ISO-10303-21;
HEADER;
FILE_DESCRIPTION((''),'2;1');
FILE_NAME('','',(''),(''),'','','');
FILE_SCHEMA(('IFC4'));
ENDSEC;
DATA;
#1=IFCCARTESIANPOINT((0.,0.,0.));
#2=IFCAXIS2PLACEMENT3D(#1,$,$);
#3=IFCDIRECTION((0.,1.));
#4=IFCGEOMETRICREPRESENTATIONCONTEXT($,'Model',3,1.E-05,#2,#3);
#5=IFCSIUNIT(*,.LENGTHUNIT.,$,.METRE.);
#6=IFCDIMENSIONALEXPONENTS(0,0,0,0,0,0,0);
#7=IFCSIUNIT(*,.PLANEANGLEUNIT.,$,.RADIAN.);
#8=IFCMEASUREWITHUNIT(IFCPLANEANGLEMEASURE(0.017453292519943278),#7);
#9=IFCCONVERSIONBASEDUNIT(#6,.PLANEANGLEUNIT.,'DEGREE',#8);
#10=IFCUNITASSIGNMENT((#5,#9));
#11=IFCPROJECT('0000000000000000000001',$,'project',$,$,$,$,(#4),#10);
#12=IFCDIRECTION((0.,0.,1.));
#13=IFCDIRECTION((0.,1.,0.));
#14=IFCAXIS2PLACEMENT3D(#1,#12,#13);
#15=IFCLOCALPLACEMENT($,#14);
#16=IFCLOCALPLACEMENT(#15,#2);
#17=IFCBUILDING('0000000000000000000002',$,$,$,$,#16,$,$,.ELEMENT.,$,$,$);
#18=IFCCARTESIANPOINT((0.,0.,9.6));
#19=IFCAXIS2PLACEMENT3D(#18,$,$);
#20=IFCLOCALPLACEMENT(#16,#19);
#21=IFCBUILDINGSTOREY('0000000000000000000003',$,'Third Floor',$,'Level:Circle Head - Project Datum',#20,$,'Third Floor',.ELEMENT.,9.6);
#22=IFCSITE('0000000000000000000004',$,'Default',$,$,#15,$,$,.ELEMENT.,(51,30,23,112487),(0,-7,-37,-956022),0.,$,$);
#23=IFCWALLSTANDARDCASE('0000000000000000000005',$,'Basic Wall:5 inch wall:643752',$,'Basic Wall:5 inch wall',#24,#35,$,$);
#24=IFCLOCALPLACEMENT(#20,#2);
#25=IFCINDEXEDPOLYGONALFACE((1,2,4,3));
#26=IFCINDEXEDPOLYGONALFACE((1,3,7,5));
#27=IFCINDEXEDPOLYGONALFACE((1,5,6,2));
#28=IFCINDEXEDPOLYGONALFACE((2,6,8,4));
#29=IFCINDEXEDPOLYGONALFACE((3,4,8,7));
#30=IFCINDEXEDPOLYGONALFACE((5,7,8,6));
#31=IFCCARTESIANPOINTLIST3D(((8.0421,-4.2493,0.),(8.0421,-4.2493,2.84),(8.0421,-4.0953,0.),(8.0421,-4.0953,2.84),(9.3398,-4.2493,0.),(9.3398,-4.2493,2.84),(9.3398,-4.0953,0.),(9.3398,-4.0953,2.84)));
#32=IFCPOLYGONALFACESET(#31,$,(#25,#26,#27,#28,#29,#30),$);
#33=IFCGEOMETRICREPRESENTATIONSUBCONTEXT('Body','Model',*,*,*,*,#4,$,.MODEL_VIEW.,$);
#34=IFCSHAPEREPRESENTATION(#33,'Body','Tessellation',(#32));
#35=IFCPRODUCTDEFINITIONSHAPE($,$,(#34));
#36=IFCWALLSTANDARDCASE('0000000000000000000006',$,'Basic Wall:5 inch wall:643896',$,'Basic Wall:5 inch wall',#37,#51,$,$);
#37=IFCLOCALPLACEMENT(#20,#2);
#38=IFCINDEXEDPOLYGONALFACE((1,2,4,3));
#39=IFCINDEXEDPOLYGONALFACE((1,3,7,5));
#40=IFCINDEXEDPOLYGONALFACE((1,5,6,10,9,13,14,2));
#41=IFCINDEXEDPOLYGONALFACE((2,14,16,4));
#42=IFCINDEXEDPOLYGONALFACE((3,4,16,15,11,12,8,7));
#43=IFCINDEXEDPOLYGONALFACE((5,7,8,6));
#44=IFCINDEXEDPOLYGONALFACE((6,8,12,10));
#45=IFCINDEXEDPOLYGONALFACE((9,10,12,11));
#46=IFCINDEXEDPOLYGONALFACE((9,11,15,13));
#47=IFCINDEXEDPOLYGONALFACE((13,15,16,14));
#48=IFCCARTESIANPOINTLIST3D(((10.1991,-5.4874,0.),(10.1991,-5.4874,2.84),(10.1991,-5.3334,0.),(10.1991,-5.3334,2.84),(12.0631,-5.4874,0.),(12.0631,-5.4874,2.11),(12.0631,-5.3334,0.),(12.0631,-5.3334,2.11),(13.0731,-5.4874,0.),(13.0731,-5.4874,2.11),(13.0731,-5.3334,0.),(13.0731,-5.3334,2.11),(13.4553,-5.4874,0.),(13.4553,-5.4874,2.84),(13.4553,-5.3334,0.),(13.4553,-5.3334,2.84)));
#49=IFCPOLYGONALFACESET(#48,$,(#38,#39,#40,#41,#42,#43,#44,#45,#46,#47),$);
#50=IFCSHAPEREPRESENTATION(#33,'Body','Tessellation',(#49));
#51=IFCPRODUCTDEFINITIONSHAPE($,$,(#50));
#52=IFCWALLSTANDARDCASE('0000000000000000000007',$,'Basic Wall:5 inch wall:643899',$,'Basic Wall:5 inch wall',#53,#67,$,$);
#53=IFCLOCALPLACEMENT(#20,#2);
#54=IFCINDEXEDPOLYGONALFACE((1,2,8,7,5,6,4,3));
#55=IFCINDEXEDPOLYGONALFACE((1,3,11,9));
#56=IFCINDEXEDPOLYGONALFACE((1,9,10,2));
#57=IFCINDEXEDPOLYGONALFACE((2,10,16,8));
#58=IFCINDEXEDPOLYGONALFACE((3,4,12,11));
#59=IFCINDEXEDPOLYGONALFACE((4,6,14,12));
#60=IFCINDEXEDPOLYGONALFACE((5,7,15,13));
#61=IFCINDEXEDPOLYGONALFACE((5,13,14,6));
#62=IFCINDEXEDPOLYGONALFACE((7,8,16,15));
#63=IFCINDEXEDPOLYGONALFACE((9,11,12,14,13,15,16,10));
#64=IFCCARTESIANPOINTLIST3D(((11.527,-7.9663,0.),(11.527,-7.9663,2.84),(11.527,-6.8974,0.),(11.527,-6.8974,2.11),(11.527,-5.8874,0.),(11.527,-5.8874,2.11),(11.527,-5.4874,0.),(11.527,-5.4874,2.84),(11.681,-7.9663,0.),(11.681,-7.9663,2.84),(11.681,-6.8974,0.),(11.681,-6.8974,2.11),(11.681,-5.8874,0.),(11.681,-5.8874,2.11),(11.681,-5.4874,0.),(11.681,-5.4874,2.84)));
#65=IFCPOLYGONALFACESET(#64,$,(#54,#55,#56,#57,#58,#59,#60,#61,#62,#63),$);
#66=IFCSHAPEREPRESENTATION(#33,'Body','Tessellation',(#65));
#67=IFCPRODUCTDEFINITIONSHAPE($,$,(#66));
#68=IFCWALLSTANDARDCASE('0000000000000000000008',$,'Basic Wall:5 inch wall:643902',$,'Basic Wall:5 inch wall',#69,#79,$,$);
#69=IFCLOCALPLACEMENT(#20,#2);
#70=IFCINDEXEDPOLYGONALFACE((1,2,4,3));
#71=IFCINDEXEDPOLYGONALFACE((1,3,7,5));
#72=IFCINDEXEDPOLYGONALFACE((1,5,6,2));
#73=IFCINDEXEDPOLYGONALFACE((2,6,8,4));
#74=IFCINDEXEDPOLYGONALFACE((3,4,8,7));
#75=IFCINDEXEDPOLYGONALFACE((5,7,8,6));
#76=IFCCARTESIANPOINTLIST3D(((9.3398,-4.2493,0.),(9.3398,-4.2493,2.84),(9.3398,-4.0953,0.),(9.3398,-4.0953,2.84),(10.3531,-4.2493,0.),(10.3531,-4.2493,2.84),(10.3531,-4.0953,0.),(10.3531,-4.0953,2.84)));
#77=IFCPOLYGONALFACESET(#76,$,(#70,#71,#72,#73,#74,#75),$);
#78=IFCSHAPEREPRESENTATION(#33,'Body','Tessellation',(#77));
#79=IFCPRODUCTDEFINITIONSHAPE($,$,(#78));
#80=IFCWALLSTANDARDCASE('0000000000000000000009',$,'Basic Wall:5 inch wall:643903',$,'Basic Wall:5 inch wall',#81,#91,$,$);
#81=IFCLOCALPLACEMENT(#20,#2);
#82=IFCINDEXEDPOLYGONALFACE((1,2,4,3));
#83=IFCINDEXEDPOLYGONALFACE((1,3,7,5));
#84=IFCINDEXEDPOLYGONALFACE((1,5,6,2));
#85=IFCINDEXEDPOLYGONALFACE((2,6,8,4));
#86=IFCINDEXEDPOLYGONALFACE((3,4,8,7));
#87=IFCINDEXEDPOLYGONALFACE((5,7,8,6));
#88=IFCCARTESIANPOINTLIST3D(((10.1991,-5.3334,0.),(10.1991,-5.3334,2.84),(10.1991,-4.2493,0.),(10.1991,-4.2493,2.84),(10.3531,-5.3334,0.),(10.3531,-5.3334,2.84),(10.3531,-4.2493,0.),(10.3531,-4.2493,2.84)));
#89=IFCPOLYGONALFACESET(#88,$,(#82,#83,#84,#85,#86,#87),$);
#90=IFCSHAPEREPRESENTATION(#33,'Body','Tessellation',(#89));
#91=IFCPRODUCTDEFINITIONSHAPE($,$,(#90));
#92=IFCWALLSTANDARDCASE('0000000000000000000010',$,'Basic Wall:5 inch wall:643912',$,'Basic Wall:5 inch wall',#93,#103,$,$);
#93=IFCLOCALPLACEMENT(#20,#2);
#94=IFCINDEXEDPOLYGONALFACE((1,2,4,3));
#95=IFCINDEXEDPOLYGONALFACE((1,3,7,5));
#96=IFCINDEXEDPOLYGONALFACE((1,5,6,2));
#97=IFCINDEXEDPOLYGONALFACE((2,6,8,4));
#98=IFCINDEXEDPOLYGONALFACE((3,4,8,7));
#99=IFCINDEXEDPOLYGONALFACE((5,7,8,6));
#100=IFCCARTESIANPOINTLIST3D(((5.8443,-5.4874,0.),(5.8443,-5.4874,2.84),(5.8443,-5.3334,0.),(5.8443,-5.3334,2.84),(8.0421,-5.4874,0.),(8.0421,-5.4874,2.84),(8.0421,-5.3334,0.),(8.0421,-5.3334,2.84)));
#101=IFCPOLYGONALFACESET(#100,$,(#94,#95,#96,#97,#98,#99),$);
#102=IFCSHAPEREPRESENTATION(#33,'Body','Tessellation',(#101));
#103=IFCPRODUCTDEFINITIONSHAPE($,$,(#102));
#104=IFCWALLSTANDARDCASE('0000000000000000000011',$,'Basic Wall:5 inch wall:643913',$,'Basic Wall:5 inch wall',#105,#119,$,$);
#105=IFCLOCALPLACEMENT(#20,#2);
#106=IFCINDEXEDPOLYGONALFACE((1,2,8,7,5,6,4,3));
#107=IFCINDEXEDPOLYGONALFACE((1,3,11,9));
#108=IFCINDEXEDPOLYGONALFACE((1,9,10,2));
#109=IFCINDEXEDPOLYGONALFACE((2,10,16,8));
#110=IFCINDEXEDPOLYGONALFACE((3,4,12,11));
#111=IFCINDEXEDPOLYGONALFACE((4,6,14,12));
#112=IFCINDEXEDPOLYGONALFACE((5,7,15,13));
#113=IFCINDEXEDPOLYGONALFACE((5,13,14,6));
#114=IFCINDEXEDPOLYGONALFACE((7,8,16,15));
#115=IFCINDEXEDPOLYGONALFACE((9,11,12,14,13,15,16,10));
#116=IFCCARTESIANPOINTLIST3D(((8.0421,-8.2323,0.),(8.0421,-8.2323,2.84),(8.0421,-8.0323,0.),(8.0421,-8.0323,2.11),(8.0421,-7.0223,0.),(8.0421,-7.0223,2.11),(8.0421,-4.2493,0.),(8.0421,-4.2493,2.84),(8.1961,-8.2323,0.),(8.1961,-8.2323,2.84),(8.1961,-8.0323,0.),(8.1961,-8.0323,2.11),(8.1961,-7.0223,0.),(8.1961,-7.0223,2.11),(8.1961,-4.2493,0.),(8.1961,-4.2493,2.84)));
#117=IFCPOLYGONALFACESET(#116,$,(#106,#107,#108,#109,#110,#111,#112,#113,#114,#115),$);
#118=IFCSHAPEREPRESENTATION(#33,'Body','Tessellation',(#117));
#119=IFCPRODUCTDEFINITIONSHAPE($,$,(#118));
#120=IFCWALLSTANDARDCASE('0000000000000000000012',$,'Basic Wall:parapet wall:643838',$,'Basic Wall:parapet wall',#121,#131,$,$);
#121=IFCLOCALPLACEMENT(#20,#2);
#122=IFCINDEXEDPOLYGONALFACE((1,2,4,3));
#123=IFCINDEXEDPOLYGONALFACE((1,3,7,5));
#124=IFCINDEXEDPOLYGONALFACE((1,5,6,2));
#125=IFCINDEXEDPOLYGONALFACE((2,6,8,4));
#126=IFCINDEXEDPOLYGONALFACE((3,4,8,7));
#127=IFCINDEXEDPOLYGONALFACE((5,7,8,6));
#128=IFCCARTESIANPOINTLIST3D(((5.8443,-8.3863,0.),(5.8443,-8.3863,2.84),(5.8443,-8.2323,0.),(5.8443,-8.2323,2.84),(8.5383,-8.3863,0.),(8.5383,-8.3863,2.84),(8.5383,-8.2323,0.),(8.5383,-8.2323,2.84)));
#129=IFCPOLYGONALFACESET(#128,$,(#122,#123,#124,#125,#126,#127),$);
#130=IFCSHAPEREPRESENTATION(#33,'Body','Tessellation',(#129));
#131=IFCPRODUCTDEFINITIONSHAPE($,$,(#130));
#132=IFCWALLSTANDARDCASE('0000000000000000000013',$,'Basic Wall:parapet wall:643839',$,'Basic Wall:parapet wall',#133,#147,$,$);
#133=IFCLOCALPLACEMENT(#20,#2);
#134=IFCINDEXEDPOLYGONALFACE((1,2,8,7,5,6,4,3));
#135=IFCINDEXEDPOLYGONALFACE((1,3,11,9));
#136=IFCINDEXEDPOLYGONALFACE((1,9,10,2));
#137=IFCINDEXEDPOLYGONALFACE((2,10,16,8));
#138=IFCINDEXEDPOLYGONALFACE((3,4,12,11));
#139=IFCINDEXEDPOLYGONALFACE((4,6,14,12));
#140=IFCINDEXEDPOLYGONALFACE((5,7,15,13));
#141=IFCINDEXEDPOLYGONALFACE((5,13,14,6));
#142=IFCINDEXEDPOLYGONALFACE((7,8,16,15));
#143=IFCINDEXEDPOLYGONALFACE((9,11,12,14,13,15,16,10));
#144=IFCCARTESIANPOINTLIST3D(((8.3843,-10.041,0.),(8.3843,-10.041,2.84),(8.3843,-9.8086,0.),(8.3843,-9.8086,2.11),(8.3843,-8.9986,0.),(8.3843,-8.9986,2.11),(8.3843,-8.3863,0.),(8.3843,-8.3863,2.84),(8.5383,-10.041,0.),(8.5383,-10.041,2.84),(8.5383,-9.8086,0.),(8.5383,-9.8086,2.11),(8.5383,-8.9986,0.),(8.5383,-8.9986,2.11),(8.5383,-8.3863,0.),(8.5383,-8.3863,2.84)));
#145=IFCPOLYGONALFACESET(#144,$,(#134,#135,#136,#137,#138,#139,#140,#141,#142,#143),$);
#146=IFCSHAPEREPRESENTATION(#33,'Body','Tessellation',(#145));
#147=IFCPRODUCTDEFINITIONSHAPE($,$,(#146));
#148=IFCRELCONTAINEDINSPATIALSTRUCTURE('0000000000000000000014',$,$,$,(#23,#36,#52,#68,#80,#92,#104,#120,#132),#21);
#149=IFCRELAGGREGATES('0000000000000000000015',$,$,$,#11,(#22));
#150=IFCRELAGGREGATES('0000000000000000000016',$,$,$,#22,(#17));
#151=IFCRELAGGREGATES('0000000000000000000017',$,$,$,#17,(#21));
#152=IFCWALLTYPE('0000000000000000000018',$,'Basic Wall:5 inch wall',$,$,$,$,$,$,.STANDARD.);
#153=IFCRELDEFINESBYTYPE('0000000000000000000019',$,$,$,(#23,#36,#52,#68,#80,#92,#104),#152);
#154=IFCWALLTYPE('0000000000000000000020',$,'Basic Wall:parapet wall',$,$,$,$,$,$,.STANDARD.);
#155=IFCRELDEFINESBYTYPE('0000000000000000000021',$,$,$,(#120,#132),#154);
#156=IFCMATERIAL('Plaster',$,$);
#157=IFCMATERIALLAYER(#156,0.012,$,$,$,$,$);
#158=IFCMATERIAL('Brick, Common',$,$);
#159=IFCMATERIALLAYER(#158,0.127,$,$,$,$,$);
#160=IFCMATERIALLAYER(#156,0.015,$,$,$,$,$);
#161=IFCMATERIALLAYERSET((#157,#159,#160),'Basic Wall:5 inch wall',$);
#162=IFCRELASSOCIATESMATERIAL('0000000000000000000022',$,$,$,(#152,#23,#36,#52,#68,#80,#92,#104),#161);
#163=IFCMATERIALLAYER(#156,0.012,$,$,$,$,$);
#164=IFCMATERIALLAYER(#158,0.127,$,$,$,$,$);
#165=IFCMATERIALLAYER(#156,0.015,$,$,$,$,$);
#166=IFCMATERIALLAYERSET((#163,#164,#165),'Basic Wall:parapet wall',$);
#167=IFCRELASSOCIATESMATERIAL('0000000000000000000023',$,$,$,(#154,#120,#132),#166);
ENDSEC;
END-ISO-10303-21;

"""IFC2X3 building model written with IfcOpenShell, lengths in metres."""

from ifc_helpers import new_model, entity, si_unit, converted_unit, direction, frame, frame_2d, origin, place, context, subcontext, project, spatial, rectangle, extrude, material, layer, layer_set, layer_usage, type_object, element, save


model = new_model("IFC2X3")

# Units and contexts
model_context = context("Model", 3, precision=1e-05, world=origin(), true_north=direction((0.0, 1.0)))
body_context = subcontext(model_context, "Body", "Model", "MODEL_VIEW")
ifc_project = project(units=[si_unit("LENGTHUNIT", "METRE"), converted_unit("PLANEANGLEUNIT", "DEGREE", entity("IfcPlaneAngleMeasure", 0.017453292519943278), si_unit("PLANEANGLEUNIT", "RADIAN"), dimensions=[0, 0, 0, 0, 0, 0, 0])], contexts=[model_context])

# Site, building, storey
site_placement = place(None, frame((0.0, 0.0, 0.0), z_axis=(0.0, 0.0, 1.0), x_axis=(0.0, 1.0, 0.0)))
site = spatial("IfcSite", under=ifc_project, at=site_placement, Name="Default", CompositionType="ELEMENT", RefLatitude=(51, 30, 23, 112487), RefLongitude=(0, -7, -37, -956022), RefElevation=0.0)
building_placement = place(site_placement, origin())
building = spatial("IfcBuilding", under=site, at=building_placement, CompositionType="ELEMENT")
storey_placement = place(building_placement, frame((0.0, 0.0, 9.6)))
storey = spatial("IfcBuildingStorey", under=building, at=storey_placement, Name="Third Floor", ObjectType="Level:Circle Head - Project Datum", LongName="Third Floor", CompositionType="ELEMENT", Elevation=9.6)

# Wall
ifc_material_1 = material(Name="Plaster")
ifc_layer_1 = layer(ifc_material_1, 0.012)
ifc_material_2 = material(Name="Brick, Common")
ifc_layer_2 = layer(ifc_material_2, 0.127)
ifc_layer_3 = layer(ifc_material_1, 0.015)
ifc_layer_set_1 = layer_set([ifc_layer_1, ifc_layer_2, ifc_layer_3], Name="Basic Wall:5 inch wall")
ifc_layer_usage_1 = layer_usage(ifc_layer_set_1, "AXIS2", "NEGATIVE", 0.077)
wall_type_1 = type_object("IfcWallType", Name="Basic Wall:5 inch wall", PredefinedType="STANDARD", material=ifc_layer_set_1)
wall_1_placement = place(storey_placement, frame((9.3398, -4.1723, 0.0), z_axis=(0.0, 0.0, 1.0), x_axis=(-1.0, 0.0, 0.0)))
element("IfcWallStandardCase", 1, at=wall_1_placement, inside=storey, type_object=wall_type_1, material=ifc_layer_usage_1, Name="Basic Wall:5 inch wall:643752", ObjectType="Basic Wall:5 inch wall", context=body_context, shape_type="SweptSolid", body=[
    extrude(rectangle(XDim=1.2977, YDim=0.154, at=frame_2d((0.6489, 0.0), x_axis=(-1.0, 0.0))), origin(), (0.0, 0.0, 1.0), 2.84),
])

# Walls, openings
ifc_layer_usage_2 = layer_usage(ifc_layer_set_1, "AXIS2", "NEGATIVE", 0.077)
wall_2_placement = place(storey_placement, frame((10.1991, -5.4104, 0.0)))
wall_2 = element("IfcWallStandardCase", 2, at=wall_2_placement, inside=storey, type_object=wall_type_1, material=ifc_layer_usage_2, Name="Basic Wall:5 inch wall:643896", ObjectType="Basic Wall:5 inch wall", context=body_context, shape_type="SweptSolid", body=[
    extrude(rectangle(XDim=3.2562, YDim=0.154, at=frame_2d((1.6281, 0.0), x_axis=(-1.0, 0.0))), origin(), (0.0, 0.0, 1.0), 2.84),
])
opening_1_placement = place(wall_2_placement, frame((1.864, -0.077, 0.0)))
element("IfcOpeningElement", 3, at=opening_1_placement, cuts=wall_2, ObjectType="Opening", context=body_context, shape_type="SweptSolid", body=[
    extrude(rectangle(XDim=2.11, YDim=1.01, at=frame_2d((1.055, 0.505), x_axis=(1.0, 0.0))), frame((0.0, 0.0, 0.0), z_axis=(0.0, 1.0, 0.0), x_axis=(0.0, 0.0, 1.0)), (0.0, 0.0, 1.0), 0.154),
])
ifc_layer_usage_3 = layer_usage(ifc_layer_set_1, "AXIS2", "NEGATIVE", 0.077)
wall_3_placement = place(storey_placement, frame((11.604, -7.9663, 0.0), z_axis=(0.0, 0.0, 1.0), x_axis=(0.0, 1.0, 0.0)))
wall_3 = element("IfcWallStandardCase", 4, at=wall_3_placement, inside=storey, type_object=wall_type_1, material=ifc_layer_usage_3, Name="Basic Wall:5 inch wall:643899", ObjectType="Basic Wall:5 inch wall", context=body_context, shape_type="SweptSolid", body=[
    extrude(rectangle(XDim=2.4789, YDim=0.154, at=frame_2d((1.2394, 0.0), x_axis=(-1.0, 0.0))), origin(), (0.0, 0.0, 1.0), 2.84),
])
opening_2_placement = place(wall_3_placement, frame((2.0789, 0.077, 0.0)))
element("IfcOpeningElement", 5, at=opening_2_placement, cuts=wall_3, ObjectType="Opening", context=body_context, shape_type="SweptSolid", body=[
    extrude(rectangle(XDim=2.11, YDim=1.01, at=frame_2d((1.055, 0.505), x_axis=(1.0, 0.0))), frame((0.0, 0.0, 0.0), z_axis=(0.0, -1.0, 0.0), x_axis=(0.0, 0.0, 1.0)), (0.0, 0.0, 1.0), 0.154),
])

# Walls
ifc_layer_usage_4 = layer_usage(ifc_layer_set_1, "AXIS2", "NEGATIVE", 0.077)
wall_4_placement = place(storey_placement, frame((9.3398, -4.1723, 0.0)))
element("IfcWallStandardCase", 6, at=wall_4_placement, inside=storey, type_object=wall_type_1, material=ifc_layer_usage_4, Name="Basic Wall:5 inch wall:643902", ObjectType="Basic Wall:5 inch wall", context=body_context, shape_type="SweptSolid", body=[
    extrude(rectangle(XDim=1.0133, YDim=0.154, at=frame_2d((0.5067, 0.0), x_axis=(-1.0, 0.0))), origin(), (0.0, 0.0, 1.0), 2.84),
])
ifc_layer_usage_5 = layer_usage(ifc_layer_set_1, "AXIS2", "NEGATIVE", 0.077)
wall_5_placement = place(storey_placement, frame((10.2761, -4.2493, 0.0), z_axis=(0.0, 0.0, 1.0), x_axis=(0.0, -1.0, 0.0)))
element("IfcWallStandardCase", 7, at=wall_5_placement, inside=storey, type_object=wall_type_1, material=ifc_layer_usage_5, Name="Basic Wall:5 inch wall:643903", ObjectType="Basic Wall:5 inch wall", context=body_context, shape_type="SweptSolid", body=[
    extrude(rectangle(XDim=1.0841, YDim=0.154, at=frame_2d((0.5421, 0.0), x_axis=(-1.0, 0.0))), origin(), (0.0, 0.0, 1.0), 2.84),
])
ifc_layer_usage_6 = layer_usage(ifc_layer_set_1, "AXIS2", "NEGATIVE", 0.077)
wall_6_placement = place(storey_placement, frame((5.8443, -5.4104, 0.0)))
element("IfcWallStandardCase", 8, at=wall_6_placement, inside=storey, type_object=wall_type_1, material=ifc_layer_usage_6, Name="Basic Wall:5 inch wall:643912", ObjectType="Basic Wall:5 inch wall", context=body_context, shape_type="SweptSolid", body=[
    extrude(rectangle(XDim=2.1978, YDim=0.154, at=frame_2d((1.0989, 0.0), x_axis=(-1.0, 0.0))), origin(), (0.0, 0.0, 1.0), 2.84),
])

# Wall, opening
ifc_layer_usage_7 = layer_usage(ifc_layer_set_1, "AXIS2", "NEGATIVE", 0.077)
wall_7_placement = place(storey_placement, frame((8.1191, -4.2493, 0.0), z_axis=(0.0, 0.0, 1.0), x_axis=(0.0, -1.0, 0.0)))
wall_7 = element("IfcWallStandardCase", 9, at=wall_7_placement, inside=storey, type_object=wall_type_1, material=ifc_layer_usage_7, Name="Basic Wall:5 inch wall:643913", ObjectType="Basic Wall:5 inch wall", context=body_context, shape_type="SweptSolid", body=[
    extrude(rectangle(XDim=3.983, YDim=0.154, at=frame_2d((1.9915, 0.0), x_axis=(1.0, 0.0))), origin(), (0.0, 0.0, 1.0), 2.84),
])
opening_3_placement = place(wall_7_placement, frame((2.773, -0.077, 0.0)))
element("IfcOpeningElement", 10, at=opening_3_placement, cuts=wall_7, ObjectType="Opening", context=body_context, shape_type="SweptSolid", body=[
    extrude(rectangle(XDim=2.11, YDim=1.01, at=frame_2d((1.055, 0.505), x_axis=(1.0, 0.0))), frame((0.0, 0.0, 0.0), z_axis=(0.0, 1.0, 0.0), x_axis=(0.0, 0.0, 1.0)), (0.0, 0.0, 1.0), 0.154),
])

# Wall
ifc_layer_4 = layer(ifc_material_1, 0.012)
ifc_layer_5 = layer(ifc_material_2, 0.127)
ifc_layer_6 = layer(ifc_material_1, 0.015)
ifc_layer_set_2 = layer_set([ifc_layer_4, ifc_layer_5, ifc_layer_6], Name="Basic Wall:parapet wall")
ifc_layer_usage_8 = layer_usage(ifc_layer_set_2, "AXIS2", "NEGATIVE", 0.077)
wall_type_2 = type_object("IfcWallType", Name="Basic Wall:parapet wall", PredefinedType="STANDARD", material=ifc_layer_set_2)
wall_8_placement = place(storey_placement, frame((5.8443, -8.3093, 0.0)))
element("IfcWallStandardCase", 11, at=wall_8_placement, inside=storey, type_object=wall_type_2, material=ifc_layer_usage_8, Name="Basic Wall:parapet wall:643838", ObjectType="Basic Wall:parapet wall", context=body_context, shape_type="SweptSolid", body=[
    extrude(rectangle(XDim=2.694, YDim=0.154, at=frame_2d((1.347, 0.0), x_axis=(-1.0, 0.0))), origin(), (0.0, 0.0, 1.0), 2.84),
])

# Wall, opening
ifc_layer_usage_9 = layer_usage(ifc_layer_set_2, "AXIS2", "NEGATIVE", 0.077)
wall_9_placement = place(storey_placement, frame((8.4613, -8.3863, 0.0), z_axis=(0.0, 0.0, 1.0), x_axis=(0.0, -1.0, 0.0)))
wall_9 = element("IfcWallStandardCase", 12, at=wall_9_placement, inside=storey, type_object=wall_type_2, material=ifc_layer_usage_9, Name="Basic Wall:parapet wall:643839", ObjectType="Basic Wall:parapet wall", context=body_context, shape_type="SweptSolid", body=[
    extrude(rectangle(XDim=1.6547, YDim=0.154, at=frame_2d((0.8273, 0.0), x_axis=(-1.0, 0.0))), origin(), (0.0, 0.0, 1.0), 2.84),
])
opening_4_placement = place(wall_9_placement, frame((0.6123, -0.077, 0.0)))
element("IfcOpeningElement", 13, at=opening_4_placement, cuts=wall_9, ObjectType="Opening", context=body_context, shape_type="SweptSolid", body=[
    extrude(rectangle(XDim=2.11, YDim=0.81, at=frame_2d((1.055, 0.405), x_axis=(1.0, 0.0))), frame((0.0, 0.0, 0.0), z_axis=(0.0, 1.0, 0.0), x_axis=(0.0, 0.0, 1.0)), (0.0, 0.0, 1.0), 0.154),
])

save(model, "model.ifc")
